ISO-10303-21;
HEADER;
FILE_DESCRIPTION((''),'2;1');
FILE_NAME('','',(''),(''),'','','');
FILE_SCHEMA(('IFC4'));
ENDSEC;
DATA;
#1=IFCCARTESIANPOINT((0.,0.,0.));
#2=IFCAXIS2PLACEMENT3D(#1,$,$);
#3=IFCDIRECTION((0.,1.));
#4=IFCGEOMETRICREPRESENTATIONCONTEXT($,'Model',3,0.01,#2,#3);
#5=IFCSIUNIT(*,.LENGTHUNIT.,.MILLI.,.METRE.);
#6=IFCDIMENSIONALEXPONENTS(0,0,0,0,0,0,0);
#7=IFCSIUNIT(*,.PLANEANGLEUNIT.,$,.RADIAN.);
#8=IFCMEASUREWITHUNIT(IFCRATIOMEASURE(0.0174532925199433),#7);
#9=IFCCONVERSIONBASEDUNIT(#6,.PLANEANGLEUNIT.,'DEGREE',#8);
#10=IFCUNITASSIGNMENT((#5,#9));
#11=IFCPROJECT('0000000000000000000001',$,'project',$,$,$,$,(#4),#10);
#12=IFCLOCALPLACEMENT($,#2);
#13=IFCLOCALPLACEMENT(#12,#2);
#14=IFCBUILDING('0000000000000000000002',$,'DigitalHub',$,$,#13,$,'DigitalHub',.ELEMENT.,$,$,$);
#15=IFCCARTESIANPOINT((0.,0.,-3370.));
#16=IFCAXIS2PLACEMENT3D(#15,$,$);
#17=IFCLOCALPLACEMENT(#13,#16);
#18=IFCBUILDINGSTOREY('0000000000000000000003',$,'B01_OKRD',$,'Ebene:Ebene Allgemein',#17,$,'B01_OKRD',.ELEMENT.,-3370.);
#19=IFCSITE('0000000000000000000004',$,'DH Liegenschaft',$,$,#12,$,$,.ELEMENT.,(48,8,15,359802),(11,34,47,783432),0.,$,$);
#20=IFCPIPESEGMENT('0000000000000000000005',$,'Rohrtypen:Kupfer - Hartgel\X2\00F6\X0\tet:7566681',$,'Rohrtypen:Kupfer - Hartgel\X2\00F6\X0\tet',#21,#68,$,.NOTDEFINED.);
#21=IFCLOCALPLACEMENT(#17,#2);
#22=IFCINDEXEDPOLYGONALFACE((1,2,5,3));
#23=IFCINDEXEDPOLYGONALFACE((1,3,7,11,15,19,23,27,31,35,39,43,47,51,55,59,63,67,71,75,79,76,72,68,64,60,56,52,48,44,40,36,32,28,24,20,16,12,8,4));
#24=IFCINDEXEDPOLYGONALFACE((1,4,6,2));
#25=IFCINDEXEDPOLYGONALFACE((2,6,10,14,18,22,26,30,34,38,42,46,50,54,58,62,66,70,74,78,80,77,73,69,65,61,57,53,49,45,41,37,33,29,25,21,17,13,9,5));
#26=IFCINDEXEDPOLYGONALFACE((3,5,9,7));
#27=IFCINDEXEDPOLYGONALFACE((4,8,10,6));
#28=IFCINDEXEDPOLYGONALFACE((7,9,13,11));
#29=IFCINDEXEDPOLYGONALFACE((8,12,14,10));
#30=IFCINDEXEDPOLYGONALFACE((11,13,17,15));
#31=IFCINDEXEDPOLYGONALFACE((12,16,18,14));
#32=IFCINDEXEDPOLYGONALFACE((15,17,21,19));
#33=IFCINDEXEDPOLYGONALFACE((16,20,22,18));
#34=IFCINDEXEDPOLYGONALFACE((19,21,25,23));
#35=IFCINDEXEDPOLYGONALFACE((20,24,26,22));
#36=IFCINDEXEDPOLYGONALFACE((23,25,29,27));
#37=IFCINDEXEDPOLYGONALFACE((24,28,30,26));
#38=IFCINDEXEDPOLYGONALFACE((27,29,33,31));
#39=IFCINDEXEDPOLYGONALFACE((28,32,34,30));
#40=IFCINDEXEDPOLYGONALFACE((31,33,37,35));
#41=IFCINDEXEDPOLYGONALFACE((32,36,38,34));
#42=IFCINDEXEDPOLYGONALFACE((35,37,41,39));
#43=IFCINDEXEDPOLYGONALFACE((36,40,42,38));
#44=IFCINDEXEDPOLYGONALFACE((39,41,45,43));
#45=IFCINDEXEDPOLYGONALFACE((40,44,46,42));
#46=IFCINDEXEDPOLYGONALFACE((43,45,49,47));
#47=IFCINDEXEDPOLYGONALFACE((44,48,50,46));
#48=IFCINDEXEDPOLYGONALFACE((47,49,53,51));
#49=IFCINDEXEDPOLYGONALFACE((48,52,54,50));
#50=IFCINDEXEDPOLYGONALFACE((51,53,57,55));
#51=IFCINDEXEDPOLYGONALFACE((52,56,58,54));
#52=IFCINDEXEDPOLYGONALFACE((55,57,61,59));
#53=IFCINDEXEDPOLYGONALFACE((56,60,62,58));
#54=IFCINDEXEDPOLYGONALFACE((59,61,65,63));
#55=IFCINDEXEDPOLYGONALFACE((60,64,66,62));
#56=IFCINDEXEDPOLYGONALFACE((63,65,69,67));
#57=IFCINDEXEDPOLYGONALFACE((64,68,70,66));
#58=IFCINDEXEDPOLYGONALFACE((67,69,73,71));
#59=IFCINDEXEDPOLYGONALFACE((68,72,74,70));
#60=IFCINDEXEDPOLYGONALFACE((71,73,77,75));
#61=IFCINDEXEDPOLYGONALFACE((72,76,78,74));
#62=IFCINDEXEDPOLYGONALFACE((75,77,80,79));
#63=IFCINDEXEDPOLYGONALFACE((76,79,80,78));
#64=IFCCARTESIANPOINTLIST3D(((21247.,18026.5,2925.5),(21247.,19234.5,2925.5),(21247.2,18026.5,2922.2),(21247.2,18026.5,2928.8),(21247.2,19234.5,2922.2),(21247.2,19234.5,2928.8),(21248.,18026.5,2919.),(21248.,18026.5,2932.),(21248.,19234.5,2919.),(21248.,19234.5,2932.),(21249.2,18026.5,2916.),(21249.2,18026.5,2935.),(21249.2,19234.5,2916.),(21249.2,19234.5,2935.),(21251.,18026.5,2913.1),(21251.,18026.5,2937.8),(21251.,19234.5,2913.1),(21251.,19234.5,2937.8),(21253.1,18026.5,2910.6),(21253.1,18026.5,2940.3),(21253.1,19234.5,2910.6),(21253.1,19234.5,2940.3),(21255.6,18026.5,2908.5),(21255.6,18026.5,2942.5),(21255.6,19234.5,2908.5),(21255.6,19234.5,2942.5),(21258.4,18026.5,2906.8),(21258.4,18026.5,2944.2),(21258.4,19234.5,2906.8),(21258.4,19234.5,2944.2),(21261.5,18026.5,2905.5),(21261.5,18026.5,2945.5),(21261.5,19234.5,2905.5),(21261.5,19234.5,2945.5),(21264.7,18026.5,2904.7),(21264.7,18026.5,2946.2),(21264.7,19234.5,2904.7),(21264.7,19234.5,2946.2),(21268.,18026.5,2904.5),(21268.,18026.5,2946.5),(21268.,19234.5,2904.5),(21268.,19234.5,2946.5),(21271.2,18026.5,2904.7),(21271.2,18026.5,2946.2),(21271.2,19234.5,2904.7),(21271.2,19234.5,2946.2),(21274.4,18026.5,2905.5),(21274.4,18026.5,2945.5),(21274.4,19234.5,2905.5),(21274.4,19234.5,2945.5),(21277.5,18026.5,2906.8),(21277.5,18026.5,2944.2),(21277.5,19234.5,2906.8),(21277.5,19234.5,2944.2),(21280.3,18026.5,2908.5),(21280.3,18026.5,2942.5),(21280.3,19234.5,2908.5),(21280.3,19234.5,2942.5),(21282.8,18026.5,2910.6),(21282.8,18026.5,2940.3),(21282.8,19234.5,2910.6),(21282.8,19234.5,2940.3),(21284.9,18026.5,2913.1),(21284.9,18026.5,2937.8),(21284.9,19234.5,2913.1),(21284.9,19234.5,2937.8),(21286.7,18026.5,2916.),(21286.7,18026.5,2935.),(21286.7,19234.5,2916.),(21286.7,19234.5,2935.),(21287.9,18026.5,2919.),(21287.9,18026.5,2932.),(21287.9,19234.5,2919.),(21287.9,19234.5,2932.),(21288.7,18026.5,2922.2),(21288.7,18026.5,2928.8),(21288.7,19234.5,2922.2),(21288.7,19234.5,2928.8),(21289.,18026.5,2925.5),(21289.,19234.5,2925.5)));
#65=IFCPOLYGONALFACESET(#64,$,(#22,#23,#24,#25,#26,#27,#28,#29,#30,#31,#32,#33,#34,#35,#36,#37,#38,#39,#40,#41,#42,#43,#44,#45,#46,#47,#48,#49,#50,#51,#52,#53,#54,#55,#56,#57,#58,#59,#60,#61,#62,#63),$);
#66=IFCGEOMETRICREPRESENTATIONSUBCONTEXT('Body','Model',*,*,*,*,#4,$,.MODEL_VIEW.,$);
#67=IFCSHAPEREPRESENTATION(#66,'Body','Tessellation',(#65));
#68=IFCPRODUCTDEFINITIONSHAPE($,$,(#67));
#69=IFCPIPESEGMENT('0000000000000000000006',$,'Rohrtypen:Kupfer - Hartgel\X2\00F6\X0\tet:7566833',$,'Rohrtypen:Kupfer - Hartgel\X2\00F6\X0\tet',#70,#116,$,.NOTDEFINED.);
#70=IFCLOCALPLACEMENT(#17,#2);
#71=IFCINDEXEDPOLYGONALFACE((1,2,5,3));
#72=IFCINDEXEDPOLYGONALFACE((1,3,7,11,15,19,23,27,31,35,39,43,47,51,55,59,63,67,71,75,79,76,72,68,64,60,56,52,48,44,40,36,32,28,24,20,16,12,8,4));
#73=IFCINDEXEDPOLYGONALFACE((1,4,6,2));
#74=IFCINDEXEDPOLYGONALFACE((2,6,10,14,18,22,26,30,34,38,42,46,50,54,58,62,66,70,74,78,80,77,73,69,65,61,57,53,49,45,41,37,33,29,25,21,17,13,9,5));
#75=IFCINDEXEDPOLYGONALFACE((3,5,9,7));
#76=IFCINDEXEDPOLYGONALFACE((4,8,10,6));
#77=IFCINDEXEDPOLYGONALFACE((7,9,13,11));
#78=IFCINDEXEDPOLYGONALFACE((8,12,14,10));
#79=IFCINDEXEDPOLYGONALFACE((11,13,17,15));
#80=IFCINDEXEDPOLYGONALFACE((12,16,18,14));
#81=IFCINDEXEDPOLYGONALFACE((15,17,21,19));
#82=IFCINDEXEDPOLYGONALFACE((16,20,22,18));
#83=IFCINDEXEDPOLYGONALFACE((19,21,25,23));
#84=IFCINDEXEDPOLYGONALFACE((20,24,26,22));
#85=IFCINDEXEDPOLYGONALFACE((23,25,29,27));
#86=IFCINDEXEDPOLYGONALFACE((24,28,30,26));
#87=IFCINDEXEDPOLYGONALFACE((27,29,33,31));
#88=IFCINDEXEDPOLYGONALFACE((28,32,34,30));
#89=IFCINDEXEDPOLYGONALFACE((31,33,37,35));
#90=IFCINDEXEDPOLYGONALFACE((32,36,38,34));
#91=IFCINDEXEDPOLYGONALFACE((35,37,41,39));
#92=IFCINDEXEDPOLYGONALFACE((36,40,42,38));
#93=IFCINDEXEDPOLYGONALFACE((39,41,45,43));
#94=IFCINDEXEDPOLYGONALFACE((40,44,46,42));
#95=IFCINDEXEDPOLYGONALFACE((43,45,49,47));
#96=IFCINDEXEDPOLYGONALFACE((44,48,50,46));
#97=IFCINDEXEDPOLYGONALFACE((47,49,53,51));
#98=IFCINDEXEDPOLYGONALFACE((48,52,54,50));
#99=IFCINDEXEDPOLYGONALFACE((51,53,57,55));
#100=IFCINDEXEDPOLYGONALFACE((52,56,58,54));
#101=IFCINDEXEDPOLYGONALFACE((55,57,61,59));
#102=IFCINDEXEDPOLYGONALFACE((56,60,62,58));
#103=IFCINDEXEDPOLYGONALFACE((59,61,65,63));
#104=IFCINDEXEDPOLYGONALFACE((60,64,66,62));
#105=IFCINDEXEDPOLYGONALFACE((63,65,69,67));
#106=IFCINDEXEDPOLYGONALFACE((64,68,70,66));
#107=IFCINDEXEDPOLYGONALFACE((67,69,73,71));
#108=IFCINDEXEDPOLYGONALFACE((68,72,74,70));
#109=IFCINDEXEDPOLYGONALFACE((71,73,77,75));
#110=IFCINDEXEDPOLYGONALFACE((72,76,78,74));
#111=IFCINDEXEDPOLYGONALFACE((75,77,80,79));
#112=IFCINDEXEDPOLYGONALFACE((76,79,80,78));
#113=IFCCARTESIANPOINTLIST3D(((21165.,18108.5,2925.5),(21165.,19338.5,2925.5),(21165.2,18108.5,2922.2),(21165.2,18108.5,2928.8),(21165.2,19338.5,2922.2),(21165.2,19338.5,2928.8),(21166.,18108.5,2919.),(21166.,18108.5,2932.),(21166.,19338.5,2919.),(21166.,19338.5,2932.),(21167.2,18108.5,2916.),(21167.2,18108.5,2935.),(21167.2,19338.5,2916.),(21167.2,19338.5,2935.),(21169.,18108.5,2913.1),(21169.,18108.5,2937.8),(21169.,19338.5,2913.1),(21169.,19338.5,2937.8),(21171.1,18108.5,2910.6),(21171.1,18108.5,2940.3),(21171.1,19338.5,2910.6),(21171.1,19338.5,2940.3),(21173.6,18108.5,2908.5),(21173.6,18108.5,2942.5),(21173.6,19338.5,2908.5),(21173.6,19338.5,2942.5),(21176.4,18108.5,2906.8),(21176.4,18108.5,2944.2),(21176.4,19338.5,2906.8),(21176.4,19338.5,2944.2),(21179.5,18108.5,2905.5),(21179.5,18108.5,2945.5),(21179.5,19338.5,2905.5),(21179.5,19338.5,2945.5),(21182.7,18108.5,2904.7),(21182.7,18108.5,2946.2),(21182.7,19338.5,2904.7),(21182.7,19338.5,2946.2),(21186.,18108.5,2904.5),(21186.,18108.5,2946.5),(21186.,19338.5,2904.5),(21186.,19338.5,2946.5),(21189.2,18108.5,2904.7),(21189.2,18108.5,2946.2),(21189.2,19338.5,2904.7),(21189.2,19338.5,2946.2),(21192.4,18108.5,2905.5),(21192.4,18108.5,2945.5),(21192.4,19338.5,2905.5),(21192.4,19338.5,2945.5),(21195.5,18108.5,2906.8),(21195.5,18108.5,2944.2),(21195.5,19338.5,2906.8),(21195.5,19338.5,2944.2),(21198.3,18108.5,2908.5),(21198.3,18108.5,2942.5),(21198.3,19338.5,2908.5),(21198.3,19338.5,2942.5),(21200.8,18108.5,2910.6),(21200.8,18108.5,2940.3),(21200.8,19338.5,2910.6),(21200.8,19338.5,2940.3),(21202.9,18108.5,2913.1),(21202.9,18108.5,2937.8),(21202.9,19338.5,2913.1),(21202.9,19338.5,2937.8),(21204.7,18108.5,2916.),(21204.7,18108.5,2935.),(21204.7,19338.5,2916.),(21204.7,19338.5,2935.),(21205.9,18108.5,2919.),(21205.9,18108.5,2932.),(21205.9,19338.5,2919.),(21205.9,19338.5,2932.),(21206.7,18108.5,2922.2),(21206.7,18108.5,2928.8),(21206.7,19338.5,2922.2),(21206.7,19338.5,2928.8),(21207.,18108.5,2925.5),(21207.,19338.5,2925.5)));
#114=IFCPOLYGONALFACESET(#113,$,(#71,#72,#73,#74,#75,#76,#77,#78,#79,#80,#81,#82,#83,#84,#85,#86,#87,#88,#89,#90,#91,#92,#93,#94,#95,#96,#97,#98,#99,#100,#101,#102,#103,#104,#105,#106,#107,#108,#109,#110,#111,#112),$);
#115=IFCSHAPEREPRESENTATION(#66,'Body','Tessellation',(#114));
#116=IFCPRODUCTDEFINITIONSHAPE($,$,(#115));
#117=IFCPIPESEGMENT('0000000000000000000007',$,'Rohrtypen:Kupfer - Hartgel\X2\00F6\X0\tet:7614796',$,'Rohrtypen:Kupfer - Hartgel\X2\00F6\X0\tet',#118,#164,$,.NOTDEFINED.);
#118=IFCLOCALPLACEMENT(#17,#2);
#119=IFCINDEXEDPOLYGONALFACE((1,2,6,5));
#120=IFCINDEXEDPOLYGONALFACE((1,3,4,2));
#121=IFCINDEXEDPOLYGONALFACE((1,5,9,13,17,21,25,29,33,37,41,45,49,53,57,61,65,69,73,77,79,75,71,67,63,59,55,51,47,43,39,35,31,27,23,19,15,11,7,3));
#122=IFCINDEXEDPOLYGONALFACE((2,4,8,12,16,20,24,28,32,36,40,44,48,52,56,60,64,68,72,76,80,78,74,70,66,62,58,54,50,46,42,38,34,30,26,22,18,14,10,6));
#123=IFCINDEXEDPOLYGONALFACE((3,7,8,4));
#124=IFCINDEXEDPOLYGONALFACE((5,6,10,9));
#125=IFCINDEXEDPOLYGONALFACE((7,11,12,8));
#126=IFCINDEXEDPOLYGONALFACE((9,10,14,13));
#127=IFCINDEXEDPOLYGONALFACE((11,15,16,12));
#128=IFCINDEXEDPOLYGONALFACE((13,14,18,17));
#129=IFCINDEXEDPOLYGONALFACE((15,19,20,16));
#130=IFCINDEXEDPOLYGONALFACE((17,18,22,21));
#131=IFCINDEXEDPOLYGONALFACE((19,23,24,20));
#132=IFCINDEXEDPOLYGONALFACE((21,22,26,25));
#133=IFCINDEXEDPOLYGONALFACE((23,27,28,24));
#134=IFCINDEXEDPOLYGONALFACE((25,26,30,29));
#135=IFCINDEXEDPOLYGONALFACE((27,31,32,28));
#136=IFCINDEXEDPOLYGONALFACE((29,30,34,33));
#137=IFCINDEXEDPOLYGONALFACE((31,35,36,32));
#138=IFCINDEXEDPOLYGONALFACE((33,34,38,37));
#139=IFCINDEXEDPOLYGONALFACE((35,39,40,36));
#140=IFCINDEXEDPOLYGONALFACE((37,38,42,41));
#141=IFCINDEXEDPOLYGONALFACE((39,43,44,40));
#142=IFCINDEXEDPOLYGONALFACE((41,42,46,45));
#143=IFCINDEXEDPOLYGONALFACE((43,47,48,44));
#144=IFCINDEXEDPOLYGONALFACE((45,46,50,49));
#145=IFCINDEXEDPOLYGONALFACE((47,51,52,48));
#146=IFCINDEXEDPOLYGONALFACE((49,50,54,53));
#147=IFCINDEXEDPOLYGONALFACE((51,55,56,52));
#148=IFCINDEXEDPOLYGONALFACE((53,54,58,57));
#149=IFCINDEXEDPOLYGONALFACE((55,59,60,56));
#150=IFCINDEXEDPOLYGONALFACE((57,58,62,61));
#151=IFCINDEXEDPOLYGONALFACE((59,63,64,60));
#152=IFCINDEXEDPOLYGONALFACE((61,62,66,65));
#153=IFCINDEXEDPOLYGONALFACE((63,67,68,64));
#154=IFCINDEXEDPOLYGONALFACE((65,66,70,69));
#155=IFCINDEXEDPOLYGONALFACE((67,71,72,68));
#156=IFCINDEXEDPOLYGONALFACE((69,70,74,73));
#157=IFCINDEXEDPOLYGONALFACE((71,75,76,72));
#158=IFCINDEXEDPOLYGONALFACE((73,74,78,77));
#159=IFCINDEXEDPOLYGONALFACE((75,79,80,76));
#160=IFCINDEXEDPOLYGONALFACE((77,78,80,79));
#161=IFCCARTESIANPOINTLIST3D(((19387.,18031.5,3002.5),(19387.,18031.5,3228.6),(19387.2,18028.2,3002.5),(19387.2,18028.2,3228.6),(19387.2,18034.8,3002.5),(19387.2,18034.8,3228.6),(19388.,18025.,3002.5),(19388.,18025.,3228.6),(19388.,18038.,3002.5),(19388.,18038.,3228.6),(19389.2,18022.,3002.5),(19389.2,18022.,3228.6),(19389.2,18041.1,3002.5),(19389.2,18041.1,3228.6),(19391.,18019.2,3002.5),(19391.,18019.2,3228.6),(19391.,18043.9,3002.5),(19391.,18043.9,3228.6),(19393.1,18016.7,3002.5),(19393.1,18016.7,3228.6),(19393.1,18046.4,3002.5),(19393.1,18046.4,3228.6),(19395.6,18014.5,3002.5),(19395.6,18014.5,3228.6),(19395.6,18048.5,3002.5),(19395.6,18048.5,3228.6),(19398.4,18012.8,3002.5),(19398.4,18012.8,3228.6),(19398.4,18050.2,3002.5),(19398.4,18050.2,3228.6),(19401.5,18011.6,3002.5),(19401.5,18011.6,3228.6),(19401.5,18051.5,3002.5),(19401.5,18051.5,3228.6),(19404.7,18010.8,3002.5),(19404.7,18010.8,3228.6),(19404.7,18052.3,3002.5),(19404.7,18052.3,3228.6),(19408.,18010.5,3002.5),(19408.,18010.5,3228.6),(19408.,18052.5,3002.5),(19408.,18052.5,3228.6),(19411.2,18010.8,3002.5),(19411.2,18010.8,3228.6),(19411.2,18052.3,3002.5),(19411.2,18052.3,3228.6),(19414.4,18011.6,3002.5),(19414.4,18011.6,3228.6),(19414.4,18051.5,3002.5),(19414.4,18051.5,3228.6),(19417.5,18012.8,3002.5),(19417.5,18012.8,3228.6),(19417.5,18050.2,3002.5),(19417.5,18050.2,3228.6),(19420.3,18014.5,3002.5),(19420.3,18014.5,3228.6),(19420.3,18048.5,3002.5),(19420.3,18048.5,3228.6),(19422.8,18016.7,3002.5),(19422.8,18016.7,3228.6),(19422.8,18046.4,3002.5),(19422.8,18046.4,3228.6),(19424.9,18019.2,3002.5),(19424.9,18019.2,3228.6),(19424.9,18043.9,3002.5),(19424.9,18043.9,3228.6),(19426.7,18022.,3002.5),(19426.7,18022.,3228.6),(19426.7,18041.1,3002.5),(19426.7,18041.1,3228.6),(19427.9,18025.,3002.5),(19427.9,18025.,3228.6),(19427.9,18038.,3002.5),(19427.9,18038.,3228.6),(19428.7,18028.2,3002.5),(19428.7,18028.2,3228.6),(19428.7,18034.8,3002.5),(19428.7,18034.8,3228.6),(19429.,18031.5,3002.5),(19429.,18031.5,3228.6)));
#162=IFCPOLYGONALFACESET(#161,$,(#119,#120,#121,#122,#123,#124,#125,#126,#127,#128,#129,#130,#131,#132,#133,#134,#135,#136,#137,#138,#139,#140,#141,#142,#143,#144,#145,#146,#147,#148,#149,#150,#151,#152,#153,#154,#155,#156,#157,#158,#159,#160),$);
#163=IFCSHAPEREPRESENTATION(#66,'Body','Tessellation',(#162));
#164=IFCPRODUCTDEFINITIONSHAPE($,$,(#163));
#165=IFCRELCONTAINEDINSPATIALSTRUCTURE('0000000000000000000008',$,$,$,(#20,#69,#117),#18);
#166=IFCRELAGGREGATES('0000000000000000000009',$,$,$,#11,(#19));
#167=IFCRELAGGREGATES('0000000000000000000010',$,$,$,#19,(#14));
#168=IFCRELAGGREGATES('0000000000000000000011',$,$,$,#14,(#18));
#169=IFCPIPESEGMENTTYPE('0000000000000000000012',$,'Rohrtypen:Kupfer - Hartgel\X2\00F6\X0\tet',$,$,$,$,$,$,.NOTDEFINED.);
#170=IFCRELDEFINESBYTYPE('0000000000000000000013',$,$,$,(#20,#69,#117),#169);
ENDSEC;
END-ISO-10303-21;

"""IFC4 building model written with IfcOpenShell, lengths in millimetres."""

from ifc_helpers import new_model, entity, si_unit, converted_unit, direction, frame, origin, place, context, subcontext, project, spatial, indexed_curve, outline, extrude, type_object, element, save


model = new_model("IFC4")

# Units and contexts
model_context = context("Model", 3, precision=0.01, world=origin(), true_north=direction((0.0, 1.0)))
body_context = subcontext(model_context, "Body", "Model", "MODEL_VIEW")
ifc_project = project(units=[si_unit("LENGTHUNIT", "METRE", prefix="MILLI"), converted_unit("PLANEANGLEUNIT", "DEGREE", entity("IfcRatioMeasure", 0.0174532925199433), si_unit("PLANEANGLEUNIT", "RADIAN"), dimensions=[0, 0, 0, 0, 0, 0, 0])], contexts=[model_context])

# Site, building, storey
site_placement = place(None, origin())
site = spatial("IfcSite", under=ifc_project, at=site_placement, Name="DH Liegenschaft", CompositionType="ELEMENT", RefLatitude=(48, 8, 15, 359802), RefLongitude=(11, 34, 47, 783432), RefElevation=0.0)
building_placement = place(site_placement, origin())
building = spatial("IfcBuilding", under=site, at=building_placement, Name="DigitalHub", LongName="DigitalHub", CompositionType="ELEMENT")
storey_placement = place(building_placement, frame((0.0, 0.0, -3370.0)))
storey = spatial("IfcBuildingStorey", under=building, at=storey_placement, Name="B01_OKRD", ObjectType="Ebene:Ebene Allgemein", LongName="B01_OKRD", CompositionType="ELEMENT", Elevation=-3370.0)

# Pipe segments
pipe_segment_type = type_object("IfcPipeSegmentType", Name="Rohrtypen:Kupfer - Hartgelötet", PredefinedType="NOTDEFINED")
pipe_segment_1_placement = place(storey_placement, frame((21245.4, 18026.5, 2902.9)))
element("IfcPipeSegment", 1, at=pipe_segment_1_placement, inside=storey, type_object=pipe_segment_type, Name="Rohrtypen:Kupfer - Hartgelötet:7566681", ObjectType="Rohrtypen:Kupfer - Hartgelötet", PredefinedType="NOTDEFINED", context=body_context, shape_type="SweptSolid", body=[
    extrude(outline(indexed_curve([(21.0, 0.0), (20.7, 3.3), (20.0, 6.5), (18.7, 9.5), (17.0, 12.3), (14.8, 14.8), (12.3, 17.0), (9.5, 18.7), (6.5, 20.0), (3.3, 20.7), (0.0, 21.0), (-3.3, 20.7), (-6.5, 20.0), (-9.5, 18.7), (-12.3, 17.0), (-14.8, 14.8), (-17.0, 12.3), (-18.7, 9.5), (-20.0, 6.5), (-20.7, 3.3), (-21.0, 0.0), (-20.7, -3.3), (-20.0, -6.5), (-18.7, -9.5), (-17.0, -12.3), (-14.8, -14.8), (-12.3, -17.0), (-9.5, -18.7), (-6.5, -20.0), (-3.3, -20.7), (0.0, -21.0), (3.3, -20.7), (6.5, -20.0), (9.5, -18.7), (12.3, -17.0), (14.8, -14.8), (17.0, -12.3), (18.7, -9.5), (20.0, -6.5), (20.7, -3.3), (21.0, 0.0)], self_intersect=False)), frame((22.6, 0.0, 22.6), z_axis=(0.0, 1.0, 0.0), x_axis=(-1.0, 0.0, 0.0)), (0.0, 0.0, 1.0), 1208.0),
])
pipe_segment_2_placement = place(storey_placement, frame((21163.4, 18108.5, 2902.9)))
element("IfcPipeSegment", 2, at=pipe_segment_2_placement, inside=storey, type_object=pipe_segment_type, Name="Rohrtypen:Kupfer - Hartgelötet:7566833", ObjectType="Rohrtypen:Kupfer - Hartgelötet", PredefinedType="NOTDEFINED", context=body_context, shape_type="SweptSolid", body=[
    extrude(outline(indexed_curve([(21.0, 0.0), (20.7, 3.3), (20.0, 6.5), (18.7, 9.5), (17.0, 12.3), (14.8, 14.8), (12.3, 17.0), (9.5, 18.7), (6.5, 20.0), (3.3, 20.7), (0.0, 21.0), (-3.3, 20.7), (-6.5, 20.0), (-9.5, 18.7), (-12.3, 17.0), (-14.8, 14.8), (-17.0, 12.3), (-18.7, 9.5), (-20.0, 6.5), (-20.7, 3.3), (-21.0, 0.0), (-20.7, -3.3), (-20.0, -6.5), (-18.7, -9.5), (-17.0, -12.3), (-14.8, -14.8), (-12.3, -17.0), (-9.5, -18.7), (-6.5, -20.0), (-3.3, -20.7), (0.0, -21.0), (3.3, -20.7), (6.5, -20.0), (9.5, -18.7), (12.3, -17.0), (14.8, -14.8), (17.0, -12.3), (18.7, -9.5), (20.0, -6.5), (20.7, -3.3), (21.0, 0.0)], self_intersect=False)), frame((22.6, 0.0, 22.6), z_axis=(0.0, 1.0, 0.0), x_axis=(-1.0, 0.0, 0.0)), (0.0, 0.0, 1.0), 1230.0),
])
pipe_segment_3_placement = place(storey_placement, frame((19385.4, 18008.9, 3002.5)))
element("IfcPipeSegment", 3, at=pipe_segment_3_placement, inside=storey, type_object=pipe_segment_type, Name="Rohrtypen:Kupfer - Hartgelötet:7614796", ObjectType="Rohrtypen:Kupfer - Hartgelötet", PredefinedType="NOTDEFINED", context=body_context, shape_type="SweptSolid", body=[
    extrude(outline(indexed_curve([(21.0, 0.0), (20.7, 3.3), (20.0, 6.5), (18.7, 9.5), (17.0, 12.3), (14.8, 14.8), (12.3, 17.0), (9.5, 18.7), (6.5, 20.0), (3.3, 20.7), (0.0, 21.0), (-3.3, 20.7), (-6.5, 20.0), (-9.5, 18.7), (-12.3, 17.0), (-14.8, 14.8), (-17.0, 12.3), (-18.7, 9.5), (-20.0, 6.5), (-20.7, 3.3), (-21.0, 0.0), (-20.7, -3.3), (-20.0, -6.5), (-18.7, -9.5), (-17.0, -12.3), (-14.8, -14.8), (-12.3, -17.0), (-9.5, -18.7), (-6.5, -20.0), (-3.3, -20.7), (0.0, -21.0), (3.3, -20.7), (6.5, -20.0), (9.5, -18.7), (12.3, -17.0), (14.8, -14.8), (17.0, -12.3), (18.7, -9.5), (20.0, -6.5), (20.7, -3.3), (21.0, 0.0)], self_intersect=False)), frame((22.6, 22.6, 0.0), z_axis=(0.0, 0.0, 1.0), x_axis=(-1.0, 0.0, 0.0)), (0.0, 0.0, 1.0), 226.1),
])

save(model, "model.ifc")
